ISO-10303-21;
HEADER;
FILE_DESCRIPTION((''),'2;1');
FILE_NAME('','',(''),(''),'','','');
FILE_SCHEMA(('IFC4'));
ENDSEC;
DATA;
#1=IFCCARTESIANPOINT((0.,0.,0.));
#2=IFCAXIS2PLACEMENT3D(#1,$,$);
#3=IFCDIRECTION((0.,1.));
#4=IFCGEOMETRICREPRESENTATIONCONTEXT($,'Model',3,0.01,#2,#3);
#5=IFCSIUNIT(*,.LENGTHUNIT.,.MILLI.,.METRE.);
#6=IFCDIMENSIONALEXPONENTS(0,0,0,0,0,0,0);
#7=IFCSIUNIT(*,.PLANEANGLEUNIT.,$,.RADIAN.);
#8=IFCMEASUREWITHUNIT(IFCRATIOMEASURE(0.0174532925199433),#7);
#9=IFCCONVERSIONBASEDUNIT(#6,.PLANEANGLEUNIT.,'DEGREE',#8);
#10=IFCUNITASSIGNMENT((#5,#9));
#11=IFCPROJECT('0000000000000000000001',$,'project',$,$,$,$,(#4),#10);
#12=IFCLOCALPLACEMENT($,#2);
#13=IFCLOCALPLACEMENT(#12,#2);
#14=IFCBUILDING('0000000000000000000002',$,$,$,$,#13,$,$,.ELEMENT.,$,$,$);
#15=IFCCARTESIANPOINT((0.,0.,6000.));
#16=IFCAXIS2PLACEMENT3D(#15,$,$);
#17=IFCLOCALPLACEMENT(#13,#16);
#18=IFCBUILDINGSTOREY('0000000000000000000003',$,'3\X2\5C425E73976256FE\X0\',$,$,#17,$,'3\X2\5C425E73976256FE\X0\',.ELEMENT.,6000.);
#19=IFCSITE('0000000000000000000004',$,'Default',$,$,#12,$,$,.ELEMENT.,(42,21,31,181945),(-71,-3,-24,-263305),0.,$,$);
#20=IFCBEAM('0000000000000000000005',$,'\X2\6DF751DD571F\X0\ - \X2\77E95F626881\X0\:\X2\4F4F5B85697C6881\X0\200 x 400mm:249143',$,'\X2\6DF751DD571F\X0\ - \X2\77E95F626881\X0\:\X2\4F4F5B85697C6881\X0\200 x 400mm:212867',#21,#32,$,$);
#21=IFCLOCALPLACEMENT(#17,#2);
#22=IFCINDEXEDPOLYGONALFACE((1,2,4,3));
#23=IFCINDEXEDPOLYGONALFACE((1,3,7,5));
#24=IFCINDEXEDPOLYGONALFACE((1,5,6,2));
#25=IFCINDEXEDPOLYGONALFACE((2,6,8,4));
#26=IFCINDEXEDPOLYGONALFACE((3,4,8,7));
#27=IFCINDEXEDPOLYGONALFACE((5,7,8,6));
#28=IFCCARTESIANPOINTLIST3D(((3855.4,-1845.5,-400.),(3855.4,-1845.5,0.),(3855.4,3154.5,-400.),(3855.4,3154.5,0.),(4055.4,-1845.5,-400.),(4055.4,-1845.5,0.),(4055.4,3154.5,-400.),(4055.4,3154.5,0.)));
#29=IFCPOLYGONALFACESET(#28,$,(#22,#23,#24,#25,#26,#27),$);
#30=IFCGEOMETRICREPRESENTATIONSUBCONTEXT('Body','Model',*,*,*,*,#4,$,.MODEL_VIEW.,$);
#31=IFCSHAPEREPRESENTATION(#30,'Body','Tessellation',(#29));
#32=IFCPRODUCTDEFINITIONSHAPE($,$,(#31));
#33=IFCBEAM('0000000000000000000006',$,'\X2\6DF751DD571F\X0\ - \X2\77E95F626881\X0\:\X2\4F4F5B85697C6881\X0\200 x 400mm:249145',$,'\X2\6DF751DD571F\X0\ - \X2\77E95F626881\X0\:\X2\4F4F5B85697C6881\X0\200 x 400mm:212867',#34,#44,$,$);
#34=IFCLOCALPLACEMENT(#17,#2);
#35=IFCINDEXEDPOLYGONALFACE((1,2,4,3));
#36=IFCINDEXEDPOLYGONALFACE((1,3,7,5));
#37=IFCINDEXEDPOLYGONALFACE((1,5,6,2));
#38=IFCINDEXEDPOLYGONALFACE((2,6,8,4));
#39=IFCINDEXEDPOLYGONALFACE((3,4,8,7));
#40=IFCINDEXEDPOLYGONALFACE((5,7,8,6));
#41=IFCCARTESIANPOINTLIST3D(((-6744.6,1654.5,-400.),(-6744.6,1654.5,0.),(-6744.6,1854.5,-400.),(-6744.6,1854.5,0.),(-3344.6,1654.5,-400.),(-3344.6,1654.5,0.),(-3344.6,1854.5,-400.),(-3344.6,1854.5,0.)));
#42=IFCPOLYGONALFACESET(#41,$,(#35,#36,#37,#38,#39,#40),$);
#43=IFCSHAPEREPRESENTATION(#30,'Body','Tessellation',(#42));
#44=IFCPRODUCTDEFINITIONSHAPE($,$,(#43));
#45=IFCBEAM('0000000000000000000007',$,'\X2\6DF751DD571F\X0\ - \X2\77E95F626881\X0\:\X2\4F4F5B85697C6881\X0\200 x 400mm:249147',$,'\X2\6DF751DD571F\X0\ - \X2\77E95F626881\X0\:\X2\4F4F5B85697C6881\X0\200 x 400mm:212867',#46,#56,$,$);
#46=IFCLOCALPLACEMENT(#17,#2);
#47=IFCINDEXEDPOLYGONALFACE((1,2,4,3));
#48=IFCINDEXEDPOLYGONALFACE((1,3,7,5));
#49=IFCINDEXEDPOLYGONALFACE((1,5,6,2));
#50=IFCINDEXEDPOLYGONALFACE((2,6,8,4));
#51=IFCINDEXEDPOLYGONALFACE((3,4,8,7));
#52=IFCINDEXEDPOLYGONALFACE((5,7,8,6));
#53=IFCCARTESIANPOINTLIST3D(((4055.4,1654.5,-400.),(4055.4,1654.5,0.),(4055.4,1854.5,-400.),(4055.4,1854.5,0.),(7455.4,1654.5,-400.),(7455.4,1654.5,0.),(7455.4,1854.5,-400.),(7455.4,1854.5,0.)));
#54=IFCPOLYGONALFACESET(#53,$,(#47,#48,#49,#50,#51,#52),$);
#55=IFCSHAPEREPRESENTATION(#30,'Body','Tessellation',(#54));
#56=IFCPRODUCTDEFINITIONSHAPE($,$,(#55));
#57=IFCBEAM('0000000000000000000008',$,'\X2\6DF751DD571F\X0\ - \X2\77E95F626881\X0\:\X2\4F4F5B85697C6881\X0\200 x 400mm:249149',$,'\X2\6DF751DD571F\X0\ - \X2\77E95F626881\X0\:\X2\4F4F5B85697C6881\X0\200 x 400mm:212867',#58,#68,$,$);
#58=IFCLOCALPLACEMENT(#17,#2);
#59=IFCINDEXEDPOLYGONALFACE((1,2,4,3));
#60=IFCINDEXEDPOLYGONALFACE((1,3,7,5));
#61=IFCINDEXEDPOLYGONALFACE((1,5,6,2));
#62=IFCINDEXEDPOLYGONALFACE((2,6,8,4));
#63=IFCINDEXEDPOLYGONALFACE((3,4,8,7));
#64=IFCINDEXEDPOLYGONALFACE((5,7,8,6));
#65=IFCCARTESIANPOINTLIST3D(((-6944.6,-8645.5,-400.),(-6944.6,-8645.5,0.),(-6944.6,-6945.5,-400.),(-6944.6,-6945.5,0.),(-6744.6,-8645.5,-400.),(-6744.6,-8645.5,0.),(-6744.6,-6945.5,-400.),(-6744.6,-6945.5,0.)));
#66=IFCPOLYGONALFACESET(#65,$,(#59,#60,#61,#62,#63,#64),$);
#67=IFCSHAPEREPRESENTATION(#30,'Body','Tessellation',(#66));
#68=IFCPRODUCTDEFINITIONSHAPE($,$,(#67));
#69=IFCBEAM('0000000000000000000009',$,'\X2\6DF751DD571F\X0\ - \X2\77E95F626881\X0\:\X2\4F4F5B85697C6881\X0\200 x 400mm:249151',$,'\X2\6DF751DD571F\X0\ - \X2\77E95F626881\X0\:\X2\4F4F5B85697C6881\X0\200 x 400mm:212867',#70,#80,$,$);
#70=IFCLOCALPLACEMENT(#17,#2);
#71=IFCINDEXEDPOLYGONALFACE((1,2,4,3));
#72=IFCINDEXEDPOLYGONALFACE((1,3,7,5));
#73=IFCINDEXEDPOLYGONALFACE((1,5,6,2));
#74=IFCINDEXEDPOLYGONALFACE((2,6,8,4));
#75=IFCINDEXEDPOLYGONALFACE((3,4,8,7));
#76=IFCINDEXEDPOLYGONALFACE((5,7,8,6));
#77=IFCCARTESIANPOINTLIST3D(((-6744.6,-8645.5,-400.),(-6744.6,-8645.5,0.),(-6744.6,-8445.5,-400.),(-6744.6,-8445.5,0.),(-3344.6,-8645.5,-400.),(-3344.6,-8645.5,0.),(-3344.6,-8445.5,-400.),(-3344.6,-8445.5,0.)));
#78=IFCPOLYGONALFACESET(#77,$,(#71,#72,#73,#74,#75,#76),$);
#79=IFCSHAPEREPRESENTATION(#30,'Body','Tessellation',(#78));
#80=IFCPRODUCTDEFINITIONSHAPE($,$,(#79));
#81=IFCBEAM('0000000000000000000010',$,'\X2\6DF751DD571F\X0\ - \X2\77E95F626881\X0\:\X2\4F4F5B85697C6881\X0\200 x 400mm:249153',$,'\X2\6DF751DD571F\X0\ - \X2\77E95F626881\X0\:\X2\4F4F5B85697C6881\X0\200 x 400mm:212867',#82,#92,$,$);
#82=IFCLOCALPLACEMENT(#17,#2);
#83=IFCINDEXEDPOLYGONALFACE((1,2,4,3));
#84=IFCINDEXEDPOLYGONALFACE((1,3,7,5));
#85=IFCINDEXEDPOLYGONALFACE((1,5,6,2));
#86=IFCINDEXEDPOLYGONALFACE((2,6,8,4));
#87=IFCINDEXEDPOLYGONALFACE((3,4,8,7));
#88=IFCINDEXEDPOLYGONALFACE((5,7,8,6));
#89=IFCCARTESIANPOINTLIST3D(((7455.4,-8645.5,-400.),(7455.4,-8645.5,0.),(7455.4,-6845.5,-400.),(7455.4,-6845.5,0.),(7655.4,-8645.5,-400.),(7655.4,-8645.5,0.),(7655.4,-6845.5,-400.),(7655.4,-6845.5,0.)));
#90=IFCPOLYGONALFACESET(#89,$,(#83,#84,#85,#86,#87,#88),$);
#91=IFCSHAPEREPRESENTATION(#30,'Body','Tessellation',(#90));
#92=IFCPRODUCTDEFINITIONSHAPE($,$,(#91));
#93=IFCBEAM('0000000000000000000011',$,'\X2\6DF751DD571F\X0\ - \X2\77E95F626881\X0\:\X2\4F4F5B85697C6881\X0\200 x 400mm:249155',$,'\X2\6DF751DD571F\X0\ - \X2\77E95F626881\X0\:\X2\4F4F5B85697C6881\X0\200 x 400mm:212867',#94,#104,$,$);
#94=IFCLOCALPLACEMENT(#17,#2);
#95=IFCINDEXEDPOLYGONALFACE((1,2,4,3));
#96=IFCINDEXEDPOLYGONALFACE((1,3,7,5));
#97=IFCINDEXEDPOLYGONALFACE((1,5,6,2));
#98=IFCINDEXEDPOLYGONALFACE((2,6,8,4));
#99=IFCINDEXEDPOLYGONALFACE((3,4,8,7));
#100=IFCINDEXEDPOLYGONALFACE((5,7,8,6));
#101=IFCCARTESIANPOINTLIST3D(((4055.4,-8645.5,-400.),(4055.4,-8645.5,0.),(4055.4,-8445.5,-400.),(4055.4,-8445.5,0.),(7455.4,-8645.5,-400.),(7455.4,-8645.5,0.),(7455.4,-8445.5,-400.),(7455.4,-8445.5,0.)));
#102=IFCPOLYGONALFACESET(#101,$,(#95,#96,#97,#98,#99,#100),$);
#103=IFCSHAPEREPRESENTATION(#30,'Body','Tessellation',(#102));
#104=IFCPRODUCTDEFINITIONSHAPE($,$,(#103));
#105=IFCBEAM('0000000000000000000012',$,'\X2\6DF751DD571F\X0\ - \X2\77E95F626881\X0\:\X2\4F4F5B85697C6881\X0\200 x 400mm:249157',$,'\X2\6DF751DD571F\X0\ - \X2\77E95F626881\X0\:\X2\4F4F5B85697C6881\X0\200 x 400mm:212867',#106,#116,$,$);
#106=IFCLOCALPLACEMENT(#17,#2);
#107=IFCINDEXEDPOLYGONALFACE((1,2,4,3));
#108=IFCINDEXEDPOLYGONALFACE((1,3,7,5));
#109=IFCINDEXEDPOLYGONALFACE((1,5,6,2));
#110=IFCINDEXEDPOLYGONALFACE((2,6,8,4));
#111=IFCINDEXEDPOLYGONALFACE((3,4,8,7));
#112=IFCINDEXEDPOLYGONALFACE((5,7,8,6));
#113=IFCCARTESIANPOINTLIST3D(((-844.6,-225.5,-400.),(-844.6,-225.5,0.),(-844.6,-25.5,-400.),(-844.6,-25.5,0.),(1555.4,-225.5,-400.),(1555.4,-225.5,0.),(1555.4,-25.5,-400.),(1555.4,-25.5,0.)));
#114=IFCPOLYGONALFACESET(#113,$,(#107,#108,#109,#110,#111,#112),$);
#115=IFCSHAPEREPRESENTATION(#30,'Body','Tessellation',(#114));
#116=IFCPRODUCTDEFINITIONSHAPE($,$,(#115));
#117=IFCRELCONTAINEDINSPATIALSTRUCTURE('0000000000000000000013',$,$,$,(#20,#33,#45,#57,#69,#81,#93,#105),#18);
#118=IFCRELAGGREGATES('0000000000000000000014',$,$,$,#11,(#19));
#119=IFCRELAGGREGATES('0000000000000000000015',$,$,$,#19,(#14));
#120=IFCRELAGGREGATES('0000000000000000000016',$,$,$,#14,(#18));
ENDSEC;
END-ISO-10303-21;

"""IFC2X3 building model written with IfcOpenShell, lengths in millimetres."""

from ifc_helpers import new_model, entity, si_unit, converted_unit, direction, frame, frame_2d, origin, origin_2d_with_axis, place, context, subcontext, project, spatial, rectangle, extrude, element, save


model = new_model("IFC2X3")

# Units and contexts
model_context = context("Model", 3, precision=0.01, world=origin(), true_north=direction((0.0, 1.0)))
body_context = subcontext(model_context, "Body", "Model", "MODEL_VIEW")
ifc_project = project(units=[si_unit("LENGTHUNIT", "METRE", prefix="MILLI"), converted_unit("PLANEANGLEUNIT", "DEGREE", entity("IfcRatioMeasure", 0.0174532925199433), si_unit("PLANEANGLEUNIT", "RADIAN"), dimensions=[0, 0, 0, 0, 0, 0, 0])], contexts=[model_context])

# Site, building, storey
site_placement = place(None, origin())
site = spatial("IfcSite", under=ifc_project, at=site_placement, Name="Default", CompositionType="ELEMENT", RefLatitude=(42, 21, 31, 181945), RefLongitude=(-71, -3, -24, -263305), RefElevation=0.0)
building_placement = place(site_placement, origin())
building = spatial("IfcBuilding", under=site, at=building_placement, CompositionType="ELEMENT")
storey_placement = place(building_placement, frame((0.0, 0.0, 6000.0)))
storey = spatial("IfcBuildingStorey", under=building, at=storey_placement, Name="3层平面图", LongName="3层平面图", CompositionType="ELEMENT", Elevation=6000.0)

# Beams
beam_1_placement = place(storey_placement, frame((3955.4, 3254.5, 0.0), z_axis=(0.0, 0.0, 1.0), x_axis=(0.0, -1.0, 0.0)))
element("IfcBeam", 1, at=beam_1_placement, inside=storey, Name="混凝土 - 矩形梁:住宅楼梁200 x 400mm:249143", ObjectType="混凝土 - 矩形梁:住宅楼梁200 x 400mm:212867", context=body_context, shape_type="SweptSolid", body=[
    extrude(rectangle(XDim=400.0, YDim=200.0, at=frame_2d((0.0, 0.0), x_axis=(1.0, 0.0))), frame((100.0, 0.0, -200.0), z_axis=(1.0, 0.0, 0.0), x_axis=(0.0, 0.0, -1.0)), (0.0, 0.0, 1.0), 5000.0),
])
beam_2_placement = place(storey_placement, frame((-6844.6, 1754.5, 0.0)))
element("IfcBeam", 2, at=beam_2_placement, inside=storey, Name="混凝土 - 矩形梁:住宅楼梁200 x 400mm:249145", ObjectType="混凝土 - 矩形梁:住宅楼梁200 x 400mm:212867", context=body_context, shape_type="SweptSolid", body=[
    extrude(rectangle(XDim=400.0, YDim=200.0, at=frame_2d((0.0, 0.0), x_axis=(1.0, 0.0))), frame((100.0, 0.0, -200.0), z_axis=(1.0, 0.0, 0.0), x_axis=(0.0, 0.0, -1.0)), (0.0, 0.0, 1.0), 3400.0),
])
beam_3_placement = place(storey_placement, frame((7555.4, 1754.5, 0.0), z_axis=(0.0, 0.0, 1.0), x_axis=(-1.0, 0.0, 0.0)))
element("IfcBeam", 3, at=beam_3_placement, inside=storey, Name="混凝土 - 矩形梁:住宅楼梁200 x 400mm:249147", ObjectType="混凝土 - 矩形梁:住宅楼梁200 x 400mm:212867", context=body_context, shape_type="SweptSolid", body=[
    extrude(rectangle(XDim=400.0, YDim=200.0, at=frame_2d((0.0, 0.0), x_axis=(1.0, 0.0))), frame((100.0, 0.0, -200.0), z_axis=(1.0, 0.0, 0.0), x_axis=(0.0, 0.0, -1.0)), (0.0, 0.0, 1.0), 3400.0),
])
beam_4_placement = place(storey_placement, frame((-6844.6, -6745.5, 0.0), z_axis=(0.0, 0.0, 1.0), x_axis=(0.0, -1.0, 0.0)))
element("IfcBeam", 4, at=beam_4_placement, inside=storey, Name="混凝土 - 矩形梁:住宅楼梁200 x 400mm:249149", ObjectType="混凝土 - 矩形梁:住宅楼梁200 x 400mm:212867", context=body_context, shape_type="SweptSolid", body=[
    extrude(rectangle(XDim=400.0, YDim=200.0, at=origin_2d_with_axis()), frame((200.0, 0.0, -200.0), z_axis=(1.0, 0.0, 0.0), x_axis=(0.0, 0.0, -1.0)), (0.0, 0.0, 1.0), 1700.0),
])
beam_5_placement = place(storey_placement, frame((-6844.6, -8545.5, 0.0)))
element("IfcBeam", 5, at=beam_5_placement, inside=storey, Name="混凝土 - 矩形梁:住宅楼梁200 x 400mm:249151", ObjectType="混凝土 - 矩形梁:住宅楼梁200 x 400mm:212867", context=body_context, shape_type="SweptSolid", body=[
    extrude(rectangle(XDim=400.0, YDim=200.0, at=frame_2d((0.0, 0.0), x_axis=(1.0, 0.0))), frame((100.0, 0.0, -200.0), z_axis=(1.0, 0.0, 0.0), x_axis=(0.0, 0.0, -1.0)), (0.0, 0.0, 1.0), 3400.0),
])
beam_6_placement = place(storey_placement, frame((7555.4, -6745.5, 0.0), z_axis=(0.0, 0.0, 1.0), x_axis=(0.0, -1.0, 0.0)))
element("IfcBeam", 6, at=beam_6_placement, inside=storey, Name="混凝土 - 矩形梁:住宅楼梁200 x 400mm:249153", ObjectType="混凝土 - 矩形梁:住宅楼梁200 x 400mm:212867", context=body_context, shape_type="SweptSolid", body=[
    extrude(rectangle(XDim=400.0, YDim=200.0, at=frame_2d((0.0, 0.0), x_axis=(1.0, 0.0))), frame((100.0, 0.0, -200.0), z_axis=(1.0, 0.0, 0.0), x_axis=(0.0, 0.0, -1.0)), (0.0, 0.0, 1.0), 1800.0),
])
beam_7_placement = place(storey_placement, frame((7555.4, -8545.5, 0.0), z_axis=(0.0, 0.0, 1.0), x_axis=(-1.0, 0.0, 0.0)))
element("IfcBeam", 7, at=beam_7_placement, inside=storey, Name="混凝土 - 矩形梁:住宅楼梁200 x 400mm:249155", ObjectType="混凝土 - 矩形梁:住宅楼梁200 x 400mm:212867", context=body_context, shape_type="SweptSolid", body=[
    extrude(rectangle(XDim=400.0, YDim=200.0, at=frame_2d((0.0, 0.0), x_axis=(1.0, 0.0))), frame((100.0, 0.0, -200.0), z_axis=(1.0, 0.0, 0.0), x_axis=(0.0, 0.0, -1.0)), (0.0, 0.0, 1.0), 3400.0),
])
beam_8_placement = place(storey_placement, frame((-944.6, -125.5, 0.0)))
element("IfcBeam", 8, at=beam_8_placement, inside=storey, Name="混凝土 - 矩形梁:住宅楼梁200 x 400mm:249157", ObjectType="混凝土 - 矩形梁:住宅楼梁200 x 400mm:212867", context=body_context, shape_type="SweptSolid", body=[
    extrude(rectangle(XDim=400.0, YDim=200.0, at=frame_2d((0.0, 0.0), x_axis=(1.0, 0.0))), frame((100.0, 0.0, -200.0), z_axis=(1.0, 0.0, 0.0), x_axis=(0.0, 0.0, -1.0)), (0.0, 0.0, 1.0), 2400.0),
])

save(model, "model.ifc")
